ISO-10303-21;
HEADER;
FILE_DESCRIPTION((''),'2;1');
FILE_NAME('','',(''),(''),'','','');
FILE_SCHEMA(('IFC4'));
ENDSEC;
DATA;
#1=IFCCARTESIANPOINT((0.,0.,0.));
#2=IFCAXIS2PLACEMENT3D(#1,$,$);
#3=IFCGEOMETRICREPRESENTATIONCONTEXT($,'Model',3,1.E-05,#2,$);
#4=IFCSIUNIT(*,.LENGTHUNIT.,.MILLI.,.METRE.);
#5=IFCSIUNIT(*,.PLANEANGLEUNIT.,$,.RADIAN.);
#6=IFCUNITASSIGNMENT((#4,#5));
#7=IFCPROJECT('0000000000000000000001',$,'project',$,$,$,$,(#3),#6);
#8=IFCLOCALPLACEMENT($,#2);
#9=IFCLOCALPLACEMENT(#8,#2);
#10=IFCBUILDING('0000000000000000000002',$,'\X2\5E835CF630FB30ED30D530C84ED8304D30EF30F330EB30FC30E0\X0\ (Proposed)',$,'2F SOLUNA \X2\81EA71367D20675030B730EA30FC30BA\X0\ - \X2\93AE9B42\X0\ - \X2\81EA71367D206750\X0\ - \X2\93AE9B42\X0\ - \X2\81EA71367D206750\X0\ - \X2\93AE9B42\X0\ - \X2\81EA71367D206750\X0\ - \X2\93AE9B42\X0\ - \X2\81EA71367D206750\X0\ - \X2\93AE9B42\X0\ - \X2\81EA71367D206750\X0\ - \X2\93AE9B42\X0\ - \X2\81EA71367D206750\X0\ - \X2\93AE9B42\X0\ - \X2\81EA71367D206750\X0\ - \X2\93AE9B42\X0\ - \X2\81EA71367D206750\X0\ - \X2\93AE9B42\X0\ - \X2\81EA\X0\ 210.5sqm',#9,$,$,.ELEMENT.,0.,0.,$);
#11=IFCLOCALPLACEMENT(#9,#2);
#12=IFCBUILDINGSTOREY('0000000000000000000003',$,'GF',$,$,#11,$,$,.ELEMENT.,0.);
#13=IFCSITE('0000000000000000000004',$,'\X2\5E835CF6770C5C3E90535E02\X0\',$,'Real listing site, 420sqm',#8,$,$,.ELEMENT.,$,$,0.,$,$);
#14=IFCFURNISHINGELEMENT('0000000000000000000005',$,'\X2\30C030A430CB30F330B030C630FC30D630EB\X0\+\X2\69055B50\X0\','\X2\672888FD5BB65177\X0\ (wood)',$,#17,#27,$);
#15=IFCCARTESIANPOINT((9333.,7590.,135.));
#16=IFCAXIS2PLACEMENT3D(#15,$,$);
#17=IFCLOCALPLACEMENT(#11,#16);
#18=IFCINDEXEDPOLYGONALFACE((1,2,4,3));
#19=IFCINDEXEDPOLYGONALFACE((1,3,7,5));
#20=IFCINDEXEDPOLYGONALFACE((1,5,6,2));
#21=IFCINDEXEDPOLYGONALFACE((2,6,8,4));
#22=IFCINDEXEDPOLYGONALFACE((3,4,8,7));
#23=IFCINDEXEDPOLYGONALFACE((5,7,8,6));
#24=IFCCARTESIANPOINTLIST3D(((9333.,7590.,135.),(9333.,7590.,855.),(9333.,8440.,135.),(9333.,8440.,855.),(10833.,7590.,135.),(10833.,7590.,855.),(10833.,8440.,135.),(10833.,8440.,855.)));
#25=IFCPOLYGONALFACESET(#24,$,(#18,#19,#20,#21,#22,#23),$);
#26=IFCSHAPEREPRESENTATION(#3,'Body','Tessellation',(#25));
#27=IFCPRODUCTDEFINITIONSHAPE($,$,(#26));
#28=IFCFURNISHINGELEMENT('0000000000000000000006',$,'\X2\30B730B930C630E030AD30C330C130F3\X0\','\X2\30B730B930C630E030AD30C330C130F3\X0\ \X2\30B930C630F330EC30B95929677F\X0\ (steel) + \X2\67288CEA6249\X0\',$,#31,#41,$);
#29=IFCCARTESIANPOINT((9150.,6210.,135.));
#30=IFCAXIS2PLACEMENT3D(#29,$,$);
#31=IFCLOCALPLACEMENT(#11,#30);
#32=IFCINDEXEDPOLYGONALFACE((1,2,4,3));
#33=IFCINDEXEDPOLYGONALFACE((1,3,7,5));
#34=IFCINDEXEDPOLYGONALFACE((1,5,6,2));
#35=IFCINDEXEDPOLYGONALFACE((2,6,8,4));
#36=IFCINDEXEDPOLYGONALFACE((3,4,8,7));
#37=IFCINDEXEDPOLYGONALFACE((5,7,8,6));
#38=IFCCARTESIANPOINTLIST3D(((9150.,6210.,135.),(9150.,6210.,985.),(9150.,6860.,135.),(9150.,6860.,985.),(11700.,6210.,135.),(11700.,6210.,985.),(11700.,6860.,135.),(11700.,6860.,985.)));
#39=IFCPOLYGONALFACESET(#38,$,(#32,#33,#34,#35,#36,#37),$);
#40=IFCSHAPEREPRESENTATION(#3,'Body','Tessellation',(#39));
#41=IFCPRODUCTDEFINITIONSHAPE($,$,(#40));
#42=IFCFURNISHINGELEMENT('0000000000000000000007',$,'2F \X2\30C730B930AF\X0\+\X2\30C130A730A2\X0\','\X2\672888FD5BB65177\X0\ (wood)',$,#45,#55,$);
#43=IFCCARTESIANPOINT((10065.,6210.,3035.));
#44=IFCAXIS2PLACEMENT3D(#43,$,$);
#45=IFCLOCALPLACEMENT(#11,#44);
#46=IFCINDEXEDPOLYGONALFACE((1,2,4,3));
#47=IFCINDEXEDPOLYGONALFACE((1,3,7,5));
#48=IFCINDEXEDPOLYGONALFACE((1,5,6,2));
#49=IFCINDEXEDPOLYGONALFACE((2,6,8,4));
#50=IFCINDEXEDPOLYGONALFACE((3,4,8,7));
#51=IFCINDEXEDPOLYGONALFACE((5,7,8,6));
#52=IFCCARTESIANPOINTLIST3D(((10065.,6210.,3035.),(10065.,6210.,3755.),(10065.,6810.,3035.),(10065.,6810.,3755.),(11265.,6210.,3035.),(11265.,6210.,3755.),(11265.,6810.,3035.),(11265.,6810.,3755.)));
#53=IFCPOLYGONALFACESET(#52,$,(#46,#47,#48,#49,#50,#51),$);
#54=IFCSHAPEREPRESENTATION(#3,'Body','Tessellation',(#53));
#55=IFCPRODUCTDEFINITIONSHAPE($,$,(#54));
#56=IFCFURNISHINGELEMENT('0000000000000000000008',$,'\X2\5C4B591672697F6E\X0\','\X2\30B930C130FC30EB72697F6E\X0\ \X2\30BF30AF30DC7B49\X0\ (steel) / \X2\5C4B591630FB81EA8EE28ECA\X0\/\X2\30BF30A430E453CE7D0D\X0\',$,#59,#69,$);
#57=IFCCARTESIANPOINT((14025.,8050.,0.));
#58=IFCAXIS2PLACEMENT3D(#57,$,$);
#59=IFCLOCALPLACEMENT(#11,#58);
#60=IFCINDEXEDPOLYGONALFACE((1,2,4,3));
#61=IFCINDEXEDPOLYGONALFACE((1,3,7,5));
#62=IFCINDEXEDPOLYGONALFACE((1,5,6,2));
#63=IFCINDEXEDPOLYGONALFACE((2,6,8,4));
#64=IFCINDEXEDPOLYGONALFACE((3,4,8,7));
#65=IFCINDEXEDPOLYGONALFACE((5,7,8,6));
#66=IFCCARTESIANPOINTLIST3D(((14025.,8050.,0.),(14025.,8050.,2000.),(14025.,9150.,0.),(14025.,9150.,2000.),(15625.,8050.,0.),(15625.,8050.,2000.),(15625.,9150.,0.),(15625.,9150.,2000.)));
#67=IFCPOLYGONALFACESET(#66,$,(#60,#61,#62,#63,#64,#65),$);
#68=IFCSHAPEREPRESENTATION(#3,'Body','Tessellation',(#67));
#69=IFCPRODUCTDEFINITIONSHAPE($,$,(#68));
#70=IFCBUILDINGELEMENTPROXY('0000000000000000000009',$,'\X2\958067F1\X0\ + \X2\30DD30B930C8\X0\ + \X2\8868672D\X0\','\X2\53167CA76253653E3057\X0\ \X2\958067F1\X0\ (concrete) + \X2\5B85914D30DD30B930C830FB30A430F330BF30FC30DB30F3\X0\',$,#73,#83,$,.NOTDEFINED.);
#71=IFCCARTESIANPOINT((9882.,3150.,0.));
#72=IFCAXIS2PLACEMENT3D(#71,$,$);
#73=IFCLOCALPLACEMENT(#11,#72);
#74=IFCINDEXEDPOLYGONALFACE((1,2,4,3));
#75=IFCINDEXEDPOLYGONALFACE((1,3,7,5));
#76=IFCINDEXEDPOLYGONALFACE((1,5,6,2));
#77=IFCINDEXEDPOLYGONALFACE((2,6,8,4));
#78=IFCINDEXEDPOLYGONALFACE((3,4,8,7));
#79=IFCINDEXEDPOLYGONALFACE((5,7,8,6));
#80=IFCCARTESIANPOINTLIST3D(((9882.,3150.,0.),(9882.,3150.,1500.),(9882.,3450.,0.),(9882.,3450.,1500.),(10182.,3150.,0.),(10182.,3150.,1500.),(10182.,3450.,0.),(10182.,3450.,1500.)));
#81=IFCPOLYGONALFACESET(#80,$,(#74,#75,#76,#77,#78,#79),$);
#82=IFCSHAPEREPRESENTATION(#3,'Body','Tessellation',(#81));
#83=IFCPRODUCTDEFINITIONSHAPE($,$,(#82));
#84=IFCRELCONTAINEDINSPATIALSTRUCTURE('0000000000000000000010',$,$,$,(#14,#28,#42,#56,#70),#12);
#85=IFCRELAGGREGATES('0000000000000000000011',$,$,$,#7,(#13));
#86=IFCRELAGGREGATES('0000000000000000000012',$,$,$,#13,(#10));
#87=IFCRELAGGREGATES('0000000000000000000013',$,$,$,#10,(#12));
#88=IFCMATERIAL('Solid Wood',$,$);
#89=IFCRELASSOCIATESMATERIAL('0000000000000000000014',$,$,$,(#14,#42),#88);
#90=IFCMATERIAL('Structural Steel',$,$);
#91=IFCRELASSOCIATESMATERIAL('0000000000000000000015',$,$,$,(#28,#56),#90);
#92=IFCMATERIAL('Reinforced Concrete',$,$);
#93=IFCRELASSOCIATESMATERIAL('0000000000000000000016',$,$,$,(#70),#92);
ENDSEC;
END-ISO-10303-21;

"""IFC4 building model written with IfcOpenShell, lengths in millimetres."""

from ifc_helpers import new_model, si_unit, frame, frame_2d, origin, place, context, project, spatial, rectangle, extrude, material, element, save


model = new_model("IFC4")

# Units and contexts
model_context = context("Model", 3, precision=1e-05, world=origin())
ifc_project = project(units=[si_unit("LENGTHUNIT", "METRE", prefix="MILLI"), si_unit("PLANEANGLEUNIT", "RADIAN")], contexts=[model_context])

# Site, building, storey
site_placement = place(None, origin())
site = spatial("IfcSite", under=ifc_project, at=site_placement, Name="広島県尾道市", ObjectType="Real listing site, 420sqm", CompositionType="ELEMENT", RefElevation=0.0)
building_placement = place(site_placement, origin())
building = spatial("IfcBuilding", under=site, at=building_placement, Name="広島・ロフト付きワンルーム (Proposed)", ObjectType="2F SOLUNA 自然素材シリーズ - 鎮魂 - 自然素材 - 鎮魂 - 自然素材 - 鎮魂 - 自然素材 - 鎮魂 - 自然素材 - 鎮魂 - 自然素材 - 鎮魂 - 自然素材 - 鎮魂 - 自然素材 - 鎮魂 - 自然素材 - 鎮魂 - 自 210.5sqm", CompositionType="ELEMENT", ElevationOfRefHeight=0.0, ElevationOfTerrain=0.0)
storey_placement = place(building_placement, origin())
storey = spatial("IfcBuildingStorey", under=building, at=storey_placement, Name="GF", CompositionType="ELEMENT", Elevation=0.0)

# Shared definitions
ifc_material_1 = material(Name="Solid Wood")

# Shared definitions
ifc_material_2 = material(Name="Reinforced Concrete")

# Shared definitions
ifc_material_3 = material(Name="Structural Steel")

# Furnishing elements
furnishing_1_placement = place(storey_placement, frame((9333.0, 7590.0, 135.0)))
element("IfcFurnishingElement", 1, at=furnishing_1_placement, inside=storey, material=ifc_material_1, Name="ダイニングテーブル+椅子", Description="木製家具 (wood)", context=model_context, shape_type="SweptSolid", body=[
    extrude(rectangle(XDim=1500.0, YDim=850.0, at=frame_2d((750.0, 425.0))), frame((9333.0, 7590.0, 135.0)), (0.0, 0.0, 1.0), 720.0),
])
furnishing_2_placement = place(storey_placement, frame((9150.0, 6210.0, 135.0)))
element("IfcFurnishingElement", 2, at=furnishing_2_placement, inside=storey, material=ifc_material_3, Name="システムキッチン", Description="システムキッチン ステンレス天板 (steel) + 木質扉", context=model_context, shape_type="SweptSolid", body=[
    extrude(rectangle(XDim=2550.0, YDim=650.0, at=frame_2d((1275.0, 325.0))), frame((9150.0, 6210.0, 135.0)), (0.0, 0.0, 1.0), 850.0),
])
furnishing_3_placement = place(storey_placement, frame((10065.0, 6210.0, 3035.0)))
element("IfcFurnishingElement", 3, at=furnishing_3_placement, inside=storey, material=ifc_material_1, Name="2F デスク+チェア", Description="木製家具 (wood)", context=model_context, shape_type="SweptSolid", body=[
    extrude(rectangle(XDim=1200.0, YDim=600.0, at=frame_2d((600.0, 300.0))), frame((10065.0, 6210.0, 3035.0)), (0.0, 0.0, 1.0), 720.0),
])
furnishing_4_placement = place(storey_placement, frame((14025.0, 8050.0, 0.0)))
element("IfcFurnishingElement", 4, at=furnishing_4_placement, inside=storey, material=ifc_material_3, Name="屋外物置", Description="スチール物置 タクボ等 (steel) / 屋外・自転車/タイヤ収納", context=model_context, shape_type="SweptSolid", body=[
    extrude(rectangle(XDim=1600.0, YDim=1100.0, at=frame_2d((800.0, 550.0))), frame((14025.0, 8050.0, 0.0)), (0.0, 0.0, 1.0), 2000.0),
])

# Building element proxy
proxy_placement = place(storey_placement, frame((9882.0, 3150.0, 0.0)))
element("IfcBuildingElementProxy", 5, at=proxy_placement, inside=storey, material=ifc_material_2, Name="門柱 + ポスト + 表札", Description="化粧打放し 門柱 (concrete) + 宅配ポスト・インターホン", PredefinedType="NOTDEFINED", context=model_context, shape_type="SweptSolid", body=[
    extrude(rectangle(XDim=300.0, YDim=300.0, at=frame_2d((150.0, 150.0))), frame((9882.0, 3150.0, 0.0)), (0.0, 0.0, 1.0), 1500.0),
])

save(model, "model.ifc")
